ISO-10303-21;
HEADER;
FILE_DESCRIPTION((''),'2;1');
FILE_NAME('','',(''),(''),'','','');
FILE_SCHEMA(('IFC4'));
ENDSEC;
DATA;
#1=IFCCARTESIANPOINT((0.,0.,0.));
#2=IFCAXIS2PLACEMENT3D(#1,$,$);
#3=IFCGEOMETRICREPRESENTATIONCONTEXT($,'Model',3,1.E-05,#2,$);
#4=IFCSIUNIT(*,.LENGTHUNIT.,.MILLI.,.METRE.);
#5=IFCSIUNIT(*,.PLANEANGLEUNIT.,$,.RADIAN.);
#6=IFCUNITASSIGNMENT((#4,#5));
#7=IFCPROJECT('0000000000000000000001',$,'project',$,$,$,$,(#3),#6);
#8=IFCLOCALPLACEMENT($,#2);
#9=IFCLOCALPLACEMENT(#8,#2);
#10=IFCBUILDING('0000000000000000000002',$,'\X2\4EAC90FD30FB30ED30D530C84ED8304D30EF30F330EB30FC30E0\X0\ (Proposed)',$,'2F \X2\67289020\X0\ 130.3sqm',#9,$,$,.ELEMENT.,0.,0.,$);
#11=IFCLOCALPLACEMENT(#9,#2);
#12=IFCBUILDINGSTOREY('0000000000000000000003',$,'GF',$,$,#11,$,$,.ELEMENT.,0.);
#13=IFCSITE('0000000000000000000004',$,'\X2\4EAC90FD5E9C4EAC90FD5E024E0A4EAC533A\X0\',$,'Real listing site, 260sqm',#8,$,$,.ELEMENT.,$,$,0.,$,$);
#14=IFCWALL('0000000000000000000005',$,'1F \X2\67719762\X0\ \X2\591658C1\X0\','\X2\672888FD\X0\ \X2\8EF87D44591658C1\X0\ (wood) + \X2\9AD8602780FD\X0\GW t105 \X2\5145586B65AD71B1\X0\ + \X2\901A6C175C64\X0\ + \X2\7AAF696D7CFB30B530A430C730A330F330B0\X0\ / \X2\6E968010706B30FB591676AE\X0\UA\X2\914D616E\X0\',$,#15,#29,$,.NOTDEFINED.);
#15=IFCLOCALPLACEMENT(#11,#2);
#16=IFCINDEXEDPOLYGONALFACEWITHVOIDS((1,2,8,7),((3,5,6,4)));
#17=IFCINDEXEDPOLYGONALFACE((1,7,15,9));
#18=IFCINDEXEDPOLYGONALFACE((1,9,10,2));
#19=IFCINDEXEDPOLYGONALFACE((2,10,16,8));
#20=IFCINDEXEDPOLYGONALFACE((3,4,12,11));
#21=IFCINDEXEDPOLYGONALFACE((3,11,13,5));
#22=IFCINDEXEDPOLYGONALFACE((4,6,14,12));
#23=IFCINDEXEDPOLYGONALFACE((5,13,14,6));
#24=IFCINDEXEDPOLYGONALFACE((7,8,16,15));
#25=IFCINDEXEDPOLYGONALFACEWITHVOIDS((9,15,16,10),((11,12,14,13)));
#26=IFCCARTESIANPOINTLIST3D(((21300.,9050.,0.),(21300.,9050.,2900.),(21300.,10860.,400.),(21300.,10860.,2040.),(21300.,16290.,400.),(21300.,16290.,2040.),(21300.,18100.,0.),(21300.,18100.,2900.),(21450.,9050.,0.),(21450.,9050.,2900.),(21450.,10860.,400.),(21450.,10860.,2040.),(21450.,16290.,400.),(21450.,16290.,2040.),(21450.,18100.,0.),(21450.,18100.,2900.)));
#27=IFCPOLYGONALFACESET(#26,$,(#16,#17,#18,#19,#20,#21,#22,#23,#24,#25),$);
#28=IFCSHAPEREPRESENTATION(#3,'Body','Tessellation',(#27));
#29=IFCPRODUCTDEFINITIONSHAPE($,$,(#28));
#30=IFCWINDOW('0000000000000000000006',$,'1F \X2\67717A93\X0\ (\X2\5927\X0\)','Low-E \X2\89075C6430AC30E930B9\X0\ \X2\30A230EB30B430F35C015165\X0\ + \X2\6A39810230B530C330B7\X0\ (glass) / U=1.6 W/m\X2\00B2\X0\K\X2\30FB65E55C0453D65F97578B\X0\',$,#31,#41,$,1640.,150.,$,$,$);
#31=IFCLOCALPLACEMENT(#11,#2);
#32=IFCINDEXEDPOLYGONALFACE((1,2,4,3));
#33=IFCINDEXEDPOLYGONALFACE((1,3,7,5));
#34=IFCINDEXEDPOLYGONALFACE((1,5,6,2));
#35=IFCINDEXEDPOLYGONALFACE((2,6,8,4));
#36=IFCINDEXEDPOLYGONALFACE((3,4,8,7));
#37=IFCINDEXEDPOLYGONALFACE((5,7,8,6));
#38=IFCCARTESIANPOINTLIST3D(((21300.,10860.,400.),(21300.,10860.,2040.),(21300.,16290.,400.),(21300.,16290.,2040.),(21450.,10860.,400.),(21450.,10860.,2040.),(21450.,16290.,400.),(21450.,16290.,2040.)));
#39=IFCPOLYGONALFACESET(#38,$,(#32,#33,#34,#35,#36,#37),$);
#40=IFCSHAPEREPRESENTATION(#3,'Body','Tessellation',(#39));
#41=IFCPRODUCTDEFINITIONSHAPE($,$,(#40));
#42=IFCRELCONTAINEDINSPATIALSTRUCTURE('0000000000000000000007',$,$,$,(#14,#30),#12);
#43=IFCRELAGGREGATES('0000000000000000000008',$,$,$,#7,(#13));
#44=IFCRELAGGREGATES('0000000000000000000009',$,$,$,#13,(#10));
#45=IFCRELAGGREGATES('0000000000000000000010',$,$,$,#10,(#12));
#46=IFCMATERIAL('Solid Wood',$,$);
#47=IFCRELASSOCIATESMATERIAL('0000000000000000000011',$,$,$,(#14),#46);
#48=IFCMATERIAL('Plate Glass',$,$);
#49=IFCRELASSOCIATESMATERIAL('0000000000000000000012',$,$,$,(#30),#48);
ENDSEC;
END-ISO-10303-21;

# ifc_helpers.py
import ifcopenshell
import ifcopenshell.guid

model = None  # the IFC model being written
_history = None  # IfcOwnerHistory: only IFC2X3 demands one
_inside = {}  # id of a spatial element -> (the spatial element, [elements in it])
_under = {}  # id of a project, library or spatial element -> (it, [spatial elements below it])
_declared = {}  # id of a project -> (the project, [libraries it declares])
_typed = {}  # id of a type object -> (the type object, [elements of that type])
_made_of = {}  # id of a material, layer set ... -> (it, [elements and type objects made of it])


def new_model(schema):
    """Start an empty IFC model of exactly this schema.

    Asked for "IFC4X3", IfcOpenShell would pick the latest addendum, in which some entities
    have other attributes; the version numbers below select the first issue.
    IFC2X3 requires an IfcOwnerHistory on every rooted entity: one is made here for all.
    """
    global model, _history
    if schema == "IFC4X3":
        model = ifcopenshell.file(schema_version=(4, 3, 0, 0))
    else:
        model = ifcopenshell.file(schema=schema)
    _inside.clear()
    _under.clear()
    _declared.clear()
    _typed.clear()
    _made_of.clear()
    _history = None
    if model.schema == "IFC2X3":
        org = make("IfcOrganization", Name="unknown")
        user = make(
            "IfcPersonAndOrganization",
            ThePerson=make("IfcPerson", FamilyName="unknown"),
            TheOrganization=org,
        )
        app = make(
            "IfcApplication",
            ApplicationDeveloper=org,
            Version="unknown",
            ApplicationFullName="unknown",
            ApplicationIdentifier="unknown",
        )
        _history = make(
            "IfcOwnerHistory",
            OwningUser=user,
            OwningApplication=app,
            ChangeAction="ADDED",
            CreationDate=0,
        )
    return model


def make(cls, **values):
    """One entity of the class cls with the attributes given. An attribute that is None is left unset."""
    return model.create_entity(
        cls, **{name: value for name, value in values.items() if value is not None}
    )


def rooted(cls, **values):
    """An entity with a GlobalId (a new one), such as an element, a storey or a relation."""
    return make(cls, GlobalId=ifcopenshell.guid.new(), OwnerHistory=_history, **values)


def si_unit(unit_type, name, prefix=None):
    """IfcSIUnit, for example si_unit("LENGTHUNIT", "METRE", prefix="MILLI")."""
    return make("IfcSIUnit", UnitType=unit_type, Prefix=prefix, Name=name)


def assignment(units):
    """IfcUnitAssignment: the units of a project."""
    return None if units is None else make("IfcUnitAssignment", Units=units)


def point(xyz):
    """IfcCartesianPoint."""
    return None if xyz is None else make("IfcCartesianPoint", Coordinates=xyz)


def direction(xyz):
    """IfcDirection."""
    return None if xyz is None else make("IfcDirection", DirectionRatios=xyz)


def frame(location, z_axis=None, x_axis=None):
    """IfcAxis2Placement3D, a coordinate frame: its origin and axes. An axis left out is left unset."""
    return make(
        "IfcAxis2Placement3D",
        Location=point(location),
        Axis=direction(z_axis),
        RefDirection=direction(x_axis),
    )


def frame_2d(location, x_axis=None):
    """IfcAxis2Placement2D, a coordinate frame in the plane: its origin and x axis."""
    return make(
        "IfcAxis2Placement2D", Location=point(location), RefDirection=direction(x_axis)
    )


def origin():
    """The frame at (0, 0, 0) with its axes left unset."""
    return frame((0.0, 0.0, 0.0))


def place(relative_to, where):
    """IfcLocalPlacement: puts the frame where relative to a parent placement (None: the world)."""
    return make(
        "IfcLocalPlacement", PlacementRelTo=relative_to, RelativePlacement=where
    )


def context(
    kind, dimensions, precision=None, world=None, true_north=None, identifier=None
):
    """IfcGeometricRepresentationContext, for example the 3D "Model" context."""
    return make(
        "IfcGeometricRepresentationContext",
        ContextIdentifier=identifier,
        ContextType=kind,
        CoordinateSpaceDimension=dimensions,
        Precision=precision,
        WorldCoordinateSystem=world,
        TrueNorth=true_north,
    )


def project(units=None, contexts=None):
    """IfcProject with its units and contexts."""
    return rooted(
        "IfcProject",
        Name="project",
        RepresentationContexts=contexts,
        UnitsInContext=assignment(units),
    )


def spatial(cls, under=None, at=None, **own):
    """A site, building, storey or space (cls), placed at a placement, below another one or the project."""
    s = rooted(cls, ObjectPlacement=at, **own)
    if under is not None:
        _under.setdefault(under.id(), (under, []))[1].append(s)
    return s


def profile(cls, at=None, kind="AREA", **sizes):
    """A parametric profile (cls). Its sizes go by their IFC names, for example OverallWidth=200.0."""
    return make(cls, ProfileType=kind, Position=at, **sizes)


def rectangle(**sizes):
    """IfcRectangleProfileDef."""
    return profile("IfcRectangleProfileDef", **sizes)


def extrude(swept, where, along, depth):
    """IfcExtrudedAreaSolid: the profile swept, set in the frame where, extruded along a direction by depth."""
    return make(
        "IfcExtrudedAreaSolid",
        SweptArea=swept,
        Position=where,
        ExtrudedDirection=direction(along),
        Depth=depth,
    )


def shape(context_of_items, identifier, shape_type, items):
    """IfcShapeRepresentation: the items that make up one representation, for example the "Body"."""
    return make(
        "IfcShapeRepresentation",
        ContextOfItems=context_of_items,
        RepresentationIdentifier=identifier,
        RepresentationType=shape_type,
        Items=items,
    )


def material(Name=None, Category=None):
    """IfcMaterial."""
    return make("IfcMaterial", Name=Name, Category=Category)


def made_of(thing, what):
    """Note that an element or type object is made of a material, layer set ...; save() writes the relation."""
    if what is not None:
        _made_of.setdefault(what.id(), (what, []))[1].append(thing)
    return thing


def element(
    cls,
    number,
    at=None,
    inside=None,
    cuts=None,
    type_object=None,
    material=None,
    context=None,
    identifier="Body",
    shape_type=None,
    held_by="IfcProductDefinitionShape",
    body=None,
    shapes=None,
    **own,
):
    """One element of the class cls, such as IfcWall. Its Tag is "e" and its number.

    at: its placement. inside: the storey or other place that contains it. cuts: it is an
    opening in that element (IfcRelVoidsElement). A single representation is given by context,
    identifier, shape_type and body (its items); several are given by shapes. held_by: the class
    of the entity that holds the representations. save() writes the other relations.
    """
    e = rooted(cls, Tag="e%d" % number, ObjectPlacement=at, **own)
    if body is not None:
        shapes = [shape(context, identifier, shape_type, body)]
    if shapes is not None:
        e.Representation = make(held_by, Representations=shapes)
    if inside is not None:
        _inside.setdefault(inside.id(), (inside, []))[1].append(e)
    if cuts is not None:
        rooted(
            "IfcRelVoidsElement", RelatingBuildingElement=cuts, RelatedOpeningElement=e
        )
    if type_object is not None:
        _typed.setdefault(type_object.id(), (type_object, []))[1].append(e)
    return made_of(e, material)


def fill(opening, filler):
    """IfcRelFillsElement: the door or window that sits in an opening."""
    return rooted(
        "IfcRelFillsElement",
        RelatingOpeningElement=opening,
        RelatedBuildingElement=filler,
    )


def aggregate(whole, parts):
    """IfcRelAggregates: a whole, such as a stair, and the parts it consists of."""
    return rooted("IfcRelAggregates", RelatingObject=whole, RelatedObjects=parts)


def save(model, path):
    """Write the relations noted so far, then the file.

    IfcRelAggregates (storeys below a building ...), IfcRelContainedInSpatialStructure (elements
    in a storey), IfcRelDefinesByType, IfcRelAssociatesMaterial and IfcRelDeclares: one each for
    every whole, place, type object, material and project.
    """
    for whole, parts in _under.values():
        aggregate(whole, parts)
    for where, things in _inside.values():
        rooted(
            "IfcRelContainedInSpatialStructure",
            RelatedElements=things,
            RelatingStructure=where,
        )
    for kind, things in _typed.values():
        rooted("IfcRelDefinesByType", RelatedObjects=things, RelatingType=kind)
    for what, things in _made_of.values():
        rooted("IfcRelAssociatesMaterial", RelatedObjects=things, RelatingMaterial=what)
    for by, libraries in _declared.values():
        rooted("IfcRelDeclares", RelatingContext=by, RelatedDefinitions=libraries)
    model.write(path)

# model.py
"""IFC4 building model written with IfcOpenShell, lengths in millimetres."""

from ifc_helpers import new_model, si_unit, frame, frame_2d, origin, place, context, project, spatial, rectangle, extrude, material, element, fill, save


model = new_model("IFC4")

# Units and contexts
model_context = context("Model", 3, precision=1e-05, world=origin())
ifc_project = project(units=[si_unit("LENGTHUNIT", "METRE", prefix="MILLI"), si_unit("PLANEANGLEUNIT", "RADIAN")], contexts=[model_context])

# Site, building, storey
site_placement = place(None, origin())
site = spatial("IfcSite", under=ifc_project, at=site_placement, Name="京都府京都市上京区", ObjectType="Real listing site, 260sqm", CompositionType="ELEMENT", RefElevation=0.0)
building_placement = place(site_placement, origin())
building = spatial("IfcBuilding", under=site, at=building_placement, Name="京都・ロフト付きワンルーム (Proposed)", ObjectType="2F 木造 130.3sqm", CompositionType="ELEMENT", ElevationOfRefHeight=0.0, ElevationOfTerrain=0.0)
storey_placement = place(building_placement, origin())
storey = spatial("IfcBuildingStorey", under=building, at=storey_placement, Name="GF", CompositionType="ELEMENT", Elevation=0.0)

# Shared definitions
ifc_material_1 = material(Name="Solid Wood")

# Wall, opening, window
wall_1_placement = place(storey_placement, frame((10650.0, 4525.0, 0.0)))
wall_1 = element("IfcWall", 1, at=wall_1_placement, inside=storey, material=ifc_material_1, Name="1F 東面 外壁", Description="木製 軸組外壁 (wood) + 高性能GW t105 充填断熱 + 通気層 + 窯業系サイディング / 準耐火・外皮UA配慮", PredefinedType="NOTDEFINED", context=model_context, shape_type="SweptSolid", body=[
    extrude(rectangle(XDim=150.0, YDim=9050.0, at=frame_2d((75.0, 4525.0))), frame((10650.0, 4525.0, 0.0)), (0.0, 0.0, 1.0), 2900.0),
])
opening_1_placement = place(storey_placement, frame((10650.0, 5430.0, 200.0)))
opening_1 = element("IfcOpeningElement", 2, at=opening_1_placement, cuts=wall_1, PredefinedType="NOTDEFINED", context=model_context, shape_type="SweptSolid", body=[
    extrude(rectangle(XDim=150.0, YDim=5430.0, at=frame_2d((75.0, 2715.0))), frame((10650.0, 5430.0, 200.0)), (0.0, 0.0, 1.0), 1640.0),
])
ifc_material_2 = material(Name="Plate Glass")
window_1_placement = place(storey_placement, frame((10650.0, 5430.0, 200.0)))
window_1 = element("IfcWindow", 3, at=window_1_placement, inside=storey, material=ifc_material_2, Name="1F 東窓 (大)", Description="Low-E 複層ガラス アルゴン封入 + 樹脂サッシ (glass) / U=1.6 W/m²K・日射取得型", OverallHeight=1640.0, OverallWidth=150.0, context=model_context, shape_type="SweptSolid", body=[
    extrude(rectangle(XDim=150.0, YDim=5430.0, at=frame_2d((75.0, 2715.0))), frame((10650.0, 5430.0, 200.0)), (0.0, 0.0, 1.0), 1640.0),
])
fill(opening_1, window_1)

save(model, "model.ifc")
